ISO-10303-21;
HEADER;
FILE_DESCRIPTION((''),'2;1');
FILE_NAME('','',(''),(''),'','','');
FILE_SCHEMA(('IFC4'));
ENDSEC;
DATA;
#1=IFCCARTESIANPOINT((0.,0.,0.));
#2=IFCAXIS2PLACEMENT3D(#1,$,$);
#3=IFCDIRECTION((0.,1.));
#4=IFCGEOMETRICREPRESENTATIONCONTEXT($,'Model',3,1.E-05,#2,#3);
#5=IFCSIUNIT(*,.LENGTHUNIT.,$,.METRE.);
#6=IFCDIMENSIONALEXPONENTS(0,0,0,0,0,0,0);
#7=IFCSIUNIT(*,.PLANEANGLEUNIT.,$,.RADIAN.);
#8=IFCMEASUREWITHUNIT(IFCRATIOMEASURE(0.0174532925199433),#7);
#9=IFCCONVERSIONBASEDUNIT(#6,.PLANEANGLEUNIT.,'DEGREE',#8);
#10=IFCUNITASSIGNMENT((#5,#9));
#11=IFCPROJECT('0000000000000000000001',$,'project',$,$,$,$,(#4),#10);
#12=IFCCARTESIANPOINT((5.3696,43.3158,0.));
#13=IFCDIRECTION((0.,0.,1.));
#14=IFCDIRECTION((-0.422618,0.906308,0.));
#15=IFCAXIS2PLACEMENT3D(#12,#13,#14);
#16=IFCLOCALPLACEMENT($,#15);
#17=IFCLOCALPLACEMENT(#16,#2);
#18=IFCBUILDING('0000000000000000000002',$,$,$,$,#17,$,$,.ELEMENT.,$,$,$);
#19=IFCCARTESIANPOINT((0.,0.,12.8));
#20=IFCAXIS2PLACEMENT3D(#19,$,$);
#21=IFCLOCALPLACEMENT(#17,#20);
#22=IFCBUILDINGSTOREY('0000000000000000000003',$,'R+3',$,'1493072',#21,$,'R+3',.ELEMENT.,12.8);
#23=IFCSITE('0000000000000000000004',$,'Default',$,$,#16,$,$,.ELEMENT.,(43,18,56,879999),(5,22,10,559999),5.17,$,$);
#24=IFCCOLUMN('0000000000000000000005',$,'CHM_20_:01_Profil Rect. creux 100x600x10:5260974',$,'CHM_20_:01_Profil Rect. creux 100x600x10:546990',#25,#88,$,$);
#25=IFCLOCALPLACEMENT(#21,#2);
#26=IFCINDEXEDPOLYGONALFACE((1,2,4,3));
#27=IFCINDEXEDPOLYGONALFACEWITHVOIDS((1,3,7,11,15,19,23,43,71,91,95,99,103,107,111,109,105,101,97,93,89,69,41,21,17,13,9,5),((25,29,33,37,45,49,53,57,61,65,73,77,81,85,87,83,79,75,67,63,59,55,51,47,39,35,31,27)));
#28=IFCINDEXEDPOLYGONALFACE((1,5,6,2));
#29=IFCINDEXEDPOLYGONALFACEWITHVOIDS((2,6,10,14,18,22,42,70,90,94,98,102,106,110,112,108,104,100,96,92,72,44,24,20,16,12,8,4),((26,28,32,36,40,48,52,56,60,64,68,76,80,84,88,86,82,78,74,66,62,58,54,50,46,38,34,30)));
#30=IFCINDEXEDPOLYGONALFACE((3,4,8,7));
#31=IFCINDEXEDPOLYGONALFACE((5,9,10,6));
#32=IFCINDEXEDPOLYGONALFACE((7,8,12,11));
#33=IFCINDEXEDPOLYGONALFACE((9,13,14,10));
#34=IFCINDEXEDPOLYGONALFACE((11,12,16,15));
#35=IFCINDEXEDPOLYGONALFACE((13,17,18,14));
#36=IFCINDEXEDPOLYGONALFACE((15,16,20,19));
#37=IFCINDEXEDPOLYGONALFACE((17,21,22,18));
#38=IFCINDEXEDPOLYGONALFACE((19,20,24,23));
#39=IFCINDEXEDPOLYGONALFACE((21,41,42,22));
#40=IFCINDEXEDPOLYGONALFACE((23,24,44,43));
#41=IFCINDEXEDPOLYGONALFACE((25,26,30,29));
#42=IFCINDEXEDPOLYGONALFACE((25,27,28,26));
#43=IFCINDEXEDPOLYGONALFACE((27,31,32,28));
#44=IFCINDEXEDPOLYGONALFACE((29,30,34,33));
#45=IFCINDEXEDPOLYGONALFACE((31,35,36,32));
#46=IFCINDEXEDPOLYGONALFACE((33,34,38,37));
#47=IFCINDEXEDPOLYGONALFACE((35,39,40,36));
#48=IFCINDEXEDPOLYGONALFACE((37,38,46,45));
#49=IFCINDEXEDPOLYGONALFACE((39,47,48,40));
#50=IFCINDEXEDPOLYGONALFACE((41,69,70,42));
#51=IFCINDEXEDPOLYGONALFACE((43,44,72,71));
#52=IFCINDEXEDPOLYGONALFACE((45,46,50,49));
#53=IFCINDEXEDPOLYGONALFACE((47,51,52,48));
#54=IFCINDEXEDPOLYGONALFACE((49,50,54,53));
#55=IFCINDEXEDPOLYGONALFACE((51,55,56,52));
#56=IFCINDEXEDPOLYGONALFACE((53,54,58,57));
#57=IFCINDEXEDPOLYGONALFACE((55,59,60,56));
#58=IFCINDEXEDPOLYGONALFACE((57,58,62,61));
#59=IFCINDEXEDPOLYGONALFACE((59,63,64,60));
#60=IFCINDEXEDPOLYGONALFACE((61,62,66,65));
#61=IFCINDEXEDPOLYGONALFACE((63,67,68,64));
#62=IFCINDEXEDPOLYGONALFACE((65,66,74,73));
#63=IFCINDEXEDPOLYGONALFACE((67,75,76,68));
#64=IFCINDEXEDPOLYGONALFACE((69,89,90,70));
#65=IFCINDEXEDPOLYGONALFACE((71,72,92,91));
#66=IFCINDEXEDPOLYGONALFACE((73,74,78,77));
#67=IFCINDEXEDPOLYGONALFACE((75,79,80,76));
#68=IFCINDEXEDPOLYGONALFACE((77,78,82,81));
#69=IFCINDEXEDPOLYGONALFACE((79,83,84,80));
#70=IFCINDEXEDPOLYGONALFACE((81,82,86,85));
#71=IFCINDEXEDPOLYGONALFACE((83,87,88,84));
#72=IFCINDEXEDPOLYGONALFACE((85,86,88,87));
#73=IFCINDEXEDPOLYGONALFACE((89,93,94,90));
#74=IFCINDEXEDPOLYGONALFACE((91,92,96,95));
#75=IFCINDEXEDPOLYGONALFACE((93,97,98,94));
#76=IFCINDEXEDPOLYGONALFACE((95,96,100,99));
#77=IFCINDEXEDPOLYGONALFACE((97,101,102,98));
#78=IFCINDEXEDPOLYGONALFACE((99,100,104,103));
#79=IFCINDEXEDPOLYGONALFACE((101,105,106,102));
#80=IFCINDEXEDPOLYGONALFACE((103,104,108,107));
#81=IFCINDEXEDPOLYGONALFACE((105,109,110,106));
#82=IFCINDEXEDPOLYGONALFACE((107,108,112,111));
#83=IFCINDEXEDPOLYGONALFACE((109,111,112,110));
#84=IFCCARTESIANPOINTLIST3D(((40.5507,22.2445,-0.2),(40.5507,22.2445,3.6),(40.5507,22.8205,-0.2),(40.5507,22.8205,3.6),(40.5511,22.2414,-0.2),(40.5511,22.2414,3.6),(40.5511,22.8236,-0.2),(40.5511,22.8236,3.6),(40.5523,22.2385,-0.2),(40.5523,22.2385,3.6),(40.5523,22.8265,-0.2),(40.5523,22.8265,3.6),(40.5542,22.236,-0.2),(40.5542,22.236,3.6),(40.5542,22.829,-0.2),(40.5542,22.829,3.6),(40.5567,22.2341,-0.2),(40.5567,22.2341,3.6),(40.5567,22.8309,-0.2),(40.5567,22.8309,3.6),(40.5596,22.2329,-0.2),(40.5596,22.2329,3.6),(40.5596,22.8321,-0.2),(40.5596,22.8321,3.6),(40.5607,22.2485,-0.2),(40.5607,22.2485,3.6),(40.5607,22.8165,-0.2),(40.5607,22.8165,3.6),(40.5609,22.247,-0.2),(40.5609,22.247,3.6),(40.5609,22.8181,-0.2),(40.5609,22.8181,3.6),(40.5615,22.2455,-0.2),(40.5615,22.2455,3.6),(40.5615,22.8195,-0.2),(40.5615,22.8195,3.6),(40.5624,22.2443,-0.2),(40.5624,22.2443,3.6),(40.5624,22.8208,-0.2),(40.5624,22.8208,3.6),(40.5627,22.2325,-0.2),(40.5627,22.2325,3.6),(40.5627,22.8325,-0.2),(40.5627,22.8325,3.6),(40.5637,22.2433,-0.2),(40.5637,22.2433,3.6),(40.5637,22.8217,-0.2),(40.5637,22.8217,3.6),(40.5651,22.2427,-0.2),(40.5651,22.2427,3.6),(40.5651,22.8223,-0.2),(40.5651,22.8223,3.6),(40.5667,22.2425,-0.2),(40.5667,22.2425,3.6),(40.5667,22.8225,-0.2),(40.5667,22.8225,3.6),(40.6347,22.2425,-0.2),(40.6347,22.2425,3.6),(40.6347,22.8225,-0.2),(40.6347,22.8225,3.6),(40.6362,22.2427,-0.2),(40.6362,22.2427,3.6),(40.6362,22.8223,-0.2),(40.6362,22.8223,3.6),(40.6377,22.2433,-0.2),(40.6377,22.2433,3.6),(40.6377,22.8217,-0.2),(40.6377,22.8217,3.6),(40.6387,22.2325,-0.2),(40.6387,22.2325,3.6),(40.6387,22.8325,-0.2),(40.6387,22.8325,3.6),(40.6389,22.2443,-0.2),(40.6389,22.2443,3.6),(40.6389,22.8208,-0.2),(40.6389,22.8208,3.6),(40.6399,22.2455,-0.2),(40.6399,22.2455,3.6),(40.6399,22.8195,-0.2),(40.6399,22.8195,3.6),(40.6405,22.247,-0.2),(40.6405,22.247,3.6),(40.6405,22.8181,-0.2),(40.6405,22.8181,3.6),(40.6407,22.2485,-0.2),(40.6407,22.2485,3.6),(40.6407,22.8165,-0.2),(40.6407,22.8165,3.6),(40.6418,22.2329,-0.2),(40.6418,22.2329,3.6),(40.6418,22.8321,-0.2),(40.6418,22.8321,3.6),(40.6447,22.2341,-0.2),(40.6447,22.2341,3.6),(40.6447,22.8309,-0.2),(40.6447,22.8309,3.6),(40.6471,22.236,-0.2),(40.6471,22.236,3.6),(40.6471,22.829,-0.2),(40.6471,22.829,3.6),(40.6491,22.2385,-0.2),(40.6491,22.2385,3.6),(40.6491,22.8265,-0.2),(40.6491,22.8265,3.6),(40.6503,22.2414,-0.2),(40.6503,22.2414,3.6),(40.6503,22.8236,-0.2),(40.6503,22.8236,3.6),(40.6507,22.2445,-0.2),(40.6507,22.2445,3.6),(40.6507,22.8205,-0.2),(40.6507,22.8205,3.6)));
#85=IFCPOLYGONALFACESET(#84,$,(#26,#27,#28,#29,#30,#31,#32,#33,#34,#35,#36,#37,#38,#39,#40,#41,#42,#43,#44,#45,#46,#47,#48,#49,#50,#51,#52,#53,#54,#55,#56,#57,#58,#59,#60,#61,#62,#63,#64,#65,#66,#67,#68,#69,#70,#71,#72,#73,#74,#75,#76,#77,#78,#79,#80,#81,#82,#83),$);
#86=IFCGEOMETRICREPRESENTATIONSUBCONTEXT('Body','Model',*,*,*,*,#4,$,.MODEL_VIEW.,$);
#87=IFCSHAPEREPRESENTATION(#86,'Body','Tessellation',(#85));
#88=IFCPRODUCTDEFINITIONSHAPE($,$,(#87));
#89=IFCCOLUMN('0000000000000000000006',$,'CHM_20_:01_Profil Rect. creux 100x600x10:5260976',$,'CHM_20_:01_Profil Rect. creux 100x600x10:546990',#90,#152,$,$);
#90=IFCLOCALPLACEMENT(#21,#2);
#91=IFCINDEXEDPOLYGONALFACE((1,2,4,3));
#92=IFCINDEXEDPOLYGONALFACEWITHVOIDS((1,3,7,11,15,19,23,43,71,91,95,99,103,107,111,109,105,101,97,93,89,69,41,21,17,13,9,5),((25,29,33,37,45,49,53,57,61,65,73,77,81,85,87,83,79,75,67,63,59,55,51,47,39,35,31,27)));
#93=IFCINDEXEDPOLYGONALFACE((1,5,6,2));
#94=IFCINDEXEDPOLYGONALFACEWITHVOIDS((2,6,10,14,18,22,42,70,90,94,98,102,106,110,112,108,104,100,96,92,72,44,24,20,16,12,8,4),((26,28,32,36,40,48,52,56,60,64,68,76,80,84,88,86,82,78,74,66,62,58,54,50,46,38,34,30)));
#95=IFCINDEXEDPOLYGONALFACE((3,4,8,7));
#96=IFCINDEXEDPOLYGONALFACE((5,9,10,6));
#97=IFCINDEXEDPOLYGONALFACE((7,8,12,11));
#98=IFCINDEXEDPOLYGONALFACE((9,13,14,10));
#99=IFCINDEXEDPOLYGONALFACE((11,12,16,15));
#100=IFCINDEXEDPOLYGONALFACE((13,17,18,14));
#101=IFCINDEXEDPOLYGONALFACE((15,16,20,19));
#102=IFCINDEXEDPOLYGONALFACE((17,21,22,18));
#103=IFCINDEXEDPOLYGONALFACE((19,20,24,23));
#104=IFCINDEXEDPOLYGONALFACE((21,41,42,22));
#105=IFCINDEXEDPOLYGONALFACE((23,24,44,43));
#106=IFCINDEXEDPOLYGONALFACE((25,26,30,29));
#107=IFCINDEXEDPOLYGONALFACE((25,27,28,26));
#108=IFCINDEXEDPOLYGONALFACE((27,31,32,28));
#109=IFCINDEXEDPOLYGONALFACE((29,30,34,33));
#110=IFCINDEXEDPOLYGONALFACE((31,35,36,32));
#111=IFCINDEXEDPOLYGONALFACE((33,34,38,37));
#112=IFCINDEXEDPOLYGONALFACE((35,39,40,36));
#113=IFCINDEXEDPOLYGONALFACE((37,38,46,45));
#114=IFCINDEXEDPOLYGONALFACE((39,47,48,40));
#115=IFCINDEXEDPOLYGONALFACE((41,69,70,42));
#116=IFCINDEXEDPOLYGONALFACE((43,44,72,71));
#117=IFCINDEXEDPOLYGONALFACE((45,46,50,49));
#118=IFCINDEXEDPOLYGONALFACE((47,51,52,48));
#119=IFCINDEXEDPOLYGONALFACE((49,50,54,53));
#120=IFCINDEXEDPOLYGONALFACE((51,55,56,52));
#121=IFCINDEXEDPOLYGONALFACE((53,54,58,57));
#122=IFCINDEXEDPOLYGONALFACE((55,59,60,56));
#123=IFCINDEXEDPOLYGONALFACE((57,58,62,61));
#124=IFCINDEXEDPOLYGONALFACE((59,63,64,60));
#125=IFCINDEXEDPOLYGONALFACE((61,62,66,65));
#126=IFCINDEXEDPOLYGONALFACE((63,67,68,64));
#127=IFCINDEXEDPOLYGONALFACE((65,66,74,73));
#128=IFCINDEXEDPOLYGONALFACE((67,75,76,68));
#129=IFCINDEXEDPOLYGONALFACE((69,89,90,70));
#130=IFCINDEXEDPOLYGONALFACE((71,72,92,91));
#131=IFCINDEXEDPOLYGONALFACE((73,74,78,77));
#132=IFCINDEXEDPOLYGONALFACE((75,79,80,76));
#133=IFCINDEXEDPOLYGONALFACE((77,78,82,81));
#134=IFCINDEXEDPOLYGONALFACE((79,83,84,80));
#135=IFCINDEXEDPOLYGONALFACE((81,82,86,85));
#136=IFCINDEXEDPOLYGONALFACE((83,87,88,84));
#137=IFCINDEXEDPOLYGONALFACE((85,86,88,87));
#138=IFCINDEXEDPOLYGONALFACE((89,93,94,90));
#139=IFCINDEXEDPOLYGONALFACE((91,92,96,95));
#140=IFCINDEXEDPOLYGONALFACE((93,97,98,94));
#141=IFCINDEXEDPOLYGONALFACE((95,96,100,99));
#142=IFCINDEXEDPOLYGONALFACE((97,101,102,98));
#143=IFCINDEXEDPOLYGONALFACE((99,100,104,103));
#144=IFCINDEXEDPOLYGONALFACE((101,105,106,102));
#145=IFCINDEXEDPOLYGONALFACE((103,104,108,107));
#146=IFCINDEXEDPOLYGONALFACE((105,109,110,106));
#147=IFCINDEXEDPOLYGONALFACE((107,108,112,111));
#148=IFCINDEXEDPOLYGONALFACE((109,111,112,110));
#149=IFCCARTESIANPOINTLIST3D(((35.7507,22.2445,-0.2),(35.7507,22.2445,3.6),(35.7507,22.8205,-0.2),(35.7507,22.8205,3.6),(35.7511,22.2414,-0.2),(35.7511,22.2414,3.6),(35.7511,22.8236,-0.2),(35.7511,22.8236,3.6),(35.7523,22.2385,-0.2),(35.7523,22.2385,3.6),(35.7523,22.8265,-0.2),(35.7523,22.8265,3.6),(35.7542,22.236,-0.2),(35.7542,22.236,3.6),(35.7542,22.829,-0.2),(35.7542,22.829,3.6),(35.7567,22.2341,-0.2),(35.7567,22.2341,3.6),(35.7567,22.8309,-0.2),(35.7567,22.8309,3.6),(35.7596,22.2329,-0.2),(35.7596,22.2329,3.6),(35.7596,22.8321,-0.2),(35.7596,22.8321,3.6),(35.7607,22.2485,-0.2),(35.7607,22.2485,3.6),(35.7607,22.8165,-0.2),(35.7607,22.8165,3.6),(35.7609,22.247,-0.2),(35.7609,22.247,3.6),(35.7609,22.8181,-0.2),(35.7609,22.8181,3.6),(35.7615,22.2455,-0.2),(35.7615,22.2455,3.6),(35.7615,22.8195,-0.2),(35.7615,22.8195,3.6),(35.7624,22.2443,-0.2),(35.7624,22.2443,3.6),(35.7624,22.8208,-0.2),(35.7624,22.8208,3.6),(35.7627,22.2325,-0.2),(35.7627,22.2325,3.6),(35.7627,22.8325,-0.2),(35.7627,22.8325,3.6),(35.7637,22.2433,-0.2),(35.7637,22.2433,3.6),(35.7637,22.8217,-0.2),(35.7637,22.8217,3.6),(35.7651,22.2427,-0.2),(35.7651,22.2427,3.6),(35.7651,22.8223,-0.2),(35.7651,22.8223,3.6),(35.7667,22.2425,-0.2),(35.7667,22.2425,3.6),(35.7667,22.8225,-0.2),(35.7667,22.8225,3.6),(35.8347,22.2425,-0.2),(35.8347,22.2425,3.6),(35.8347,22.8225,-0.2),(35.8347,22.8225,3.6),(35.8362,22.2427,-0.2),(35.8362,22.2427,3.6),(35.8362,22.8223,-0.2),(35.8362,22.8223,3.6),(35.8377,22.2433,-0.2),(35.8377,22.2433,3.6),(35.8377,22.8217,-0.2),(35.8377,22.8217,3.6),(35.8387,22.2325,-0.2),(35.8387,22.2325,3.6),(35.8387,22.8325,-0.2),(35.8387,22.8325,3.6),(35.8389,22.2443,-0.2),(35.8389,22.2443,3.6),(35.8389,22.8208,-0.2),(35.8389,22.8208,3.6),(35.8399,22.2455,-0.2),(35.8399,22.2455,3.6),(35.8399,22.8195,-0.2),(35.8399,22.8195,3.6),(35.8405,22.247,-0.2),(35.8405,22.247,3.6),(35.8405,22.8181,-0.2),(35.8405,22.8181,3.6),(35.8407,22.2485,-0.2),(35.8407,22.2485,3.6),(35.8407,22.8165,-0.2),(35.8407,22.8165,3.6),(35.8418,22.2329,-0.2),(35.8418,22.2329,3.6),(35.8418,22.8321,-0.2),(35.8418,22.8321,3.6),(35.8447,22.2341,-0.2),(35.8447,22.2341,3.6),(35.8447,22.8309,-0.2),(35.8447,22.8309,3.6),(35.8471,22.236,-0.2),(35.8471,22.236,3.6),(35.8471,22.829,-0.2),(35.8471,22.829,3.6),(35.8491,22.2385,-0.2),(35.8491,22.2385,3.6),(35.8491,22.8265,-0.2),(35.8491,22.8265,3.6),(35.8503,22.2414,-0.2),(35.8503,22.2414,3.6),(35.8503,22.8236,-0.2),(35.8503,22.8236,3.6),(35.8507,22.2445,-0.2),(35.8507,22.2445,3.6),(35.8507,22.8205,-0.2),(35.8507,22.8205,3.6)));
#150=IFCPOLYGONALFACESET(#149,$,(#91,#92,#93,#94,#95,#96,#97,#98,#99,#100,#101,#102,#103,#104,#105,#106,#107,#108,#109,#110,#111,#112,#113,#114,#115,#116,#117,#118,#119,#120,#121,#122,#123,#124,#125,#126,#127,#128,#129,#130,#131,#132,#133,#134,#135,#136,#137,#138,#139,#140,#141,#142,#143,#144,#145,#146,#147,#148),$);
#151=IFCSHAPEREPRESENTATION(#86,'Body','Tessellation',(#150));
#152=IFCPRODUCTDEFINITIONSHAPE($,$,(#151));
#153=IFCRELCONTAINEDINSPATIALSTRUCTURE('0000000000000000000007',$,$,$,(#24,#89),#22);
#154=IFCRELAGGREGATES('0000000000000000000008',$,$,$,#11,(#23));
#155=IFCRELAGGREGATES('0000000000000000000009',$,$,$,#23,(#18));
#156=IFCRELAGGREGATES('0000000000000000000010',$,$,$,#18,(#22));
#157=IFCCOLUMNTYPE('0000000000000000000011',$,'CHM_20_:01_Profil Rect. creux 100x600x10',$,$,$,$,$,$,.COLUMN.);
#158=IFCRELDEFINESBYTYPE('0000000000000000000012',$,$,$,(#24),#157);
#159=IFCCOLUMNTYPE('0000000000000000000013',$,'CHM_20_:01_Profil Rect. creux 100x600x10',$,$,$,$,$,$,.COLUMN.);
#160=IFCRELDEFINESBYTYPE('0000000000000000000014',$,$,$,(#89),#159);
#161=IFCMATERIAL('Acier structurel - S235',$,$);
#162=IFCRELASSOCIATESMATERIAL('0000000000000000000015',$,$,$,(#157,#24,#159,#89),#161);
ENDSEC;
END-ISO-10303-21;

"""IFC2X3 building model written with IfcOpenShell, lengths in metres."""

from ifc_helpers import new_model, entity, si_unit, converted_unit, direction, frame, frame_2d, origin, place, context, subcontext, project, spatial, polyline, circle_curve, parameter, trimmed, segment, composite_curve, outline, extrude, source, transform, mapped, material, type_object, type_shapes, element, save


model = new_model("IFC2X3")

# Units and contexts
model_context = context("Model", 3, precision=1e-05, world=origin(), true_north=direction((0.0, 1.0)))
body_context = subcontext(model_context, "Body", "Model", "MODEL_VIEW")
ifc_project = project(units=[si_unit("LENGTHUNIT", "METRE"), converted_unit("PLANEANGLEUNIT", "DEGREE", entity("IfcRatioMeasure", 0.0174532925199433), si_unit("PLANEANGLEUNIT", "RADIAN"), dimensions=[0, 0, 0, 0, 0, 0, 0])], contexts=[model_context])

# Site, building, storey
site_placement = place(None, frame((5.3696, 43.3158, 0.0), z_axis=(0.0, 0.0, 1.0), x_axis=(-0.422618, 0.906308, 0.0)))
site = spatial("IfcSite", under=ifc_project, at=site_placement, Name="Default", CompositionType="ELEMENT", RefLatitude=(43, 18, 56, 879999), RefLongitude=(5, 22, 10, 559999), RefElevation=5.17)
building_placement = place(site_placement, origin())
building = spatial("IfcBuilding", under=site, at=building_placement, CompositionType="ELEMENT")
storey_placement = place(building_placement, frame((0.0, 0.0, 12.8)))
storey = spatial("IfcBuildingStorey", under=building, at=storey_placement, Name="R+3", ObjectType="1493072", LongName="R+3", CompositionType="ELEMENT", Elevation=12.8)

# Columns
ifc_material_1 = material(Name="Acier structurel - S235")
column_type_1 = type_object("IfcColumnType", Name="CHM_20_:01_Profil Rect. creux 100x600x10", PredefinedType="COLUMN", material=ifc_material_1)
shared_shape_1 = source(origin(), body_context, "Body", "SweptSolid", [
    extrude(outline(composite_curve([segment(polyline([(-0.038, -0.3), (0.038, -0.3)]), True, "CONTINUOUS"), segment(trimmed(circle_curve(frame_2d((0.038, -0.288), x_axis=(-1.0, 0.0)), 0.012), [parameter(90.0)], [parameter(180.0)], True, "PARAMETER"), True, "CONTINUOUS"), segment(polyline([(0.05, -0.288), (0.05, 0.288)]), True, "CONTINUOUS"), segment(trimmed(circle_curve(frame_2d((0.038, 0.288), x_axis=(-1.0, 0.0)), 0.012), [parameter(180.0)], [parameter(270.0)], True, "PARAMETER"), True, "CONTINUOUS"), segment(polyline([(0.038, 0.3), (-0.038, 0.3)]), True, "CONTINUOUS"), segment(trimmed(circle_curve(frame_2d((-0.038, 0.288), x_axis=(-1.0, 0.0)), 0.012), [parameter(270.0)], [parameter(360.0)], True, "PARAMETER"), True, "CONTINUOUS"), segment(polyline([(-0.05, 0.288), (-0.05, -0.288)]), True, "CONTINUOUS"), segment(trimmed(circle_curve(frame_2d((-0.038, -0.288), x_axis=(-1.0, 0.0)), 0.012), [parameter(360.0)], [parameter(90.0)], True, "PARAMETER"), True, "CONTINUOUS")], self_intersect=False), holes=[composite_curve([segment(trimmed(circle_curve(frame_2d((-0.034, -0.284), x_axis=(-1.0, 0.0)), 0.006), [parameter(0.0)], [parameter(90.0)], True, "PARAMETER"), False, "CONTINUOUS"), segment(polyline([(-0.04, -0.284), (-0.04, 0.284)]), True, "CONTINUOUS"), segment(trimmed(circle_curve(frame_2d((-0.034, 0.284), x_axis=(-1.0, 0.0)), 0.006), [parameter(270.0)], [parameter(0.0)], True, "PARAMETER"), False, "CONTINUOUS"), segment(polyline([(-0.034, 0.29), (0.034, 0.29)]), True, "CONTINUOUS"), segment(trimmed(circle_curve(frame_2d((0.034, 0.284), x_axis=(-1.0, 0.0)), 0.006), [parameter(180.0)], [parameter(270.0)], True, "PARAMETER"), False, "CONTINUOUS"), segment(polyline([(0.04, 0.284), (0.04, -0.284)]), True, "CONTINUOUS"), segment(trimmed(circle_curve(frame_2d((0.034, -0.284), x_axis=(-1.0, 0.0)), 0.006), [parameter(90.0)], [parameter(180.0)], True, "PARAMETER"), False, "CONTINUOUS"), segment(polyline([(0.034, -0.29), (-0.034, -0.29)]), True, "CONTINUOUS")], self_intersect=False)]), frame((40.6007, 22.5325, 12.6)), (0.0, 0.0, 1.0), 3.8),
])
type_shapes(column_type_1, [shared_shape_1])
column_1_placement = place(storey_placement, frame((0.0, 0.0, -12.8)))
element("IfcColumn", 1, at=column_1_placement, inside=storey, type_object=column_type_1, material=ifc_material_1, Name="CHM_20_:01_Profil Rect. creux 100x600x10:5260974", ObjectType="CHM_20_:01_Profil Rect. creux 100x600x10:546990", context=body_context, shape_type="MappedRepresentation", body=[
    mapped(shared_shape_1, transform((0.0, 0.0, 0.0), scale=1.0)),
])
column_type_2 = type_object("IfcColumnType", Name="CHM_20_:01_Profil Rect. creux 100x600x10", PredefinedType="COLUMN", material=ifc_material_1)
shared_shape_2 = source(origin(), body_context, "Body", "SweptSolid", [
    extrude(outline(composite_curve([segment(polyline([(-0.038, -0.3), (0.038, -0.3)]), True, "CONTINUOUS"), segment(trimmed(circle_curve(frame_2d((0.038, -0.288), x_axis=(-1.0, 0.0)), 0.012), [parameter(90.0)], [parameter(180.0)], True, "PARAMETER"), True, "CONTINUOUS"), segment(polyline([(0.05, -0.288), (0.05, 0.288)]), True, "CONTINUOUS"), segment(trimmed(circle_curve(frame_2d((0.038, 0.288), x_axis=(-1.0, 0.0)), 0.012), [parameter(180.0)], [parameter(270.0)], True, "PARAMETER"), True, "CONTINUOUS"), segment(polyline([(0.038, 0.3), (-0.038, 0.3)]), True, "CONTINUOUS"), segment(trimmed(circle_curve(frame_2d((-0.038, 0.288), x_axis=(-1.0, 0.0)), 0.012), [parameter(270.0)], [parameter(360.0)], True, "PARAMETER"), True, "CONTINUOUS"), segment(polyline([(-0.05, 0.288), (-0.05, -0.288)]), True, "CONTINUOUS"), segment(trimmed(circle_curve(frame_2d((-0.038, -0.288), x_axis=(-1.0, 0.0)), 0.012), [parameter(360.0)], [parameter(90.0)], True, "PARAMETER"), True, "CONTINUOUS")], self_intersect=False), holes=[composite_curve([segment(trimmed(circle_curve(frame_2d((-0.034, -0.284), x_axis=(-1.0, 0.0)), 0.006), [parameter(0.0)], [parameter(90.0)], True, "PARAMETER"), False, "CONTINUOUS"), segment(polyline([(-0.04, -0.284), (-0.04, 0.284)]), True, "CONTINUOUS"), segment(trimmed(circle_curve(frame_2d((-0.034, 0.284), x_axis=(-1.0, 0.0)), 0.006), [parameter(270.0)], [parameter(0.0)], True, "PARAMETER"), False, "CONTINUOUS"), segment(polyline([(-0.034, 0.29), (0.034, 0.29)]), True, "CONTINUOUS"), segment(trimmed(circle_curve(frame_2d((0.034, 0.284), x_axis=(-1.0, 0.0)), 0.006), [parameter(180.0)], [parameter(270.0)], True, "PARAMETER"), False, "CONTINUOUS"), segment(polyline([(0.04, 0.284), (0.04, -0.284)]), True, "CONTINUOUS"), segment(trimmed(circle_curve(frame_2d((0.034, -0.284), x_axis=(-1.0, 0.0)), 0.006), [parameter(90.0)], [parameter(180.0)], True, "PARAMETER"), False, "CONTINUOUS"), segment(polyline([(0.034, -0.29), (-0.034, -0.29)]), True, "CONTINUOUS")], self_intersect=False)]), frame((35.8007, 22.5325, 12.6)), (0.0, 0.0, 1.0), 3.8),
])
type_shapes(column_type_2, [shared_shape_2])
column_2_placement = place(storey_placement, frame((0.0, 0.0, -12.8)))
element("IfcColumn", 2, at=column_2_placement, inside=storey, type_object=column_type_2, material=ifc_material_1, Name="CHM_20_:01_Profil Rect. creux 100x600x10:5260976", ObjectType="CHM_20_:01_Profil Rect. creux 100x600x10:546990", context=body_context, shape_type="MappedRepresentation", body=[
    mapped(shared_shape_2, transform((0.0, 0.0, 0.0), scale=1.0)),
])

save(model, "model.ifc")
